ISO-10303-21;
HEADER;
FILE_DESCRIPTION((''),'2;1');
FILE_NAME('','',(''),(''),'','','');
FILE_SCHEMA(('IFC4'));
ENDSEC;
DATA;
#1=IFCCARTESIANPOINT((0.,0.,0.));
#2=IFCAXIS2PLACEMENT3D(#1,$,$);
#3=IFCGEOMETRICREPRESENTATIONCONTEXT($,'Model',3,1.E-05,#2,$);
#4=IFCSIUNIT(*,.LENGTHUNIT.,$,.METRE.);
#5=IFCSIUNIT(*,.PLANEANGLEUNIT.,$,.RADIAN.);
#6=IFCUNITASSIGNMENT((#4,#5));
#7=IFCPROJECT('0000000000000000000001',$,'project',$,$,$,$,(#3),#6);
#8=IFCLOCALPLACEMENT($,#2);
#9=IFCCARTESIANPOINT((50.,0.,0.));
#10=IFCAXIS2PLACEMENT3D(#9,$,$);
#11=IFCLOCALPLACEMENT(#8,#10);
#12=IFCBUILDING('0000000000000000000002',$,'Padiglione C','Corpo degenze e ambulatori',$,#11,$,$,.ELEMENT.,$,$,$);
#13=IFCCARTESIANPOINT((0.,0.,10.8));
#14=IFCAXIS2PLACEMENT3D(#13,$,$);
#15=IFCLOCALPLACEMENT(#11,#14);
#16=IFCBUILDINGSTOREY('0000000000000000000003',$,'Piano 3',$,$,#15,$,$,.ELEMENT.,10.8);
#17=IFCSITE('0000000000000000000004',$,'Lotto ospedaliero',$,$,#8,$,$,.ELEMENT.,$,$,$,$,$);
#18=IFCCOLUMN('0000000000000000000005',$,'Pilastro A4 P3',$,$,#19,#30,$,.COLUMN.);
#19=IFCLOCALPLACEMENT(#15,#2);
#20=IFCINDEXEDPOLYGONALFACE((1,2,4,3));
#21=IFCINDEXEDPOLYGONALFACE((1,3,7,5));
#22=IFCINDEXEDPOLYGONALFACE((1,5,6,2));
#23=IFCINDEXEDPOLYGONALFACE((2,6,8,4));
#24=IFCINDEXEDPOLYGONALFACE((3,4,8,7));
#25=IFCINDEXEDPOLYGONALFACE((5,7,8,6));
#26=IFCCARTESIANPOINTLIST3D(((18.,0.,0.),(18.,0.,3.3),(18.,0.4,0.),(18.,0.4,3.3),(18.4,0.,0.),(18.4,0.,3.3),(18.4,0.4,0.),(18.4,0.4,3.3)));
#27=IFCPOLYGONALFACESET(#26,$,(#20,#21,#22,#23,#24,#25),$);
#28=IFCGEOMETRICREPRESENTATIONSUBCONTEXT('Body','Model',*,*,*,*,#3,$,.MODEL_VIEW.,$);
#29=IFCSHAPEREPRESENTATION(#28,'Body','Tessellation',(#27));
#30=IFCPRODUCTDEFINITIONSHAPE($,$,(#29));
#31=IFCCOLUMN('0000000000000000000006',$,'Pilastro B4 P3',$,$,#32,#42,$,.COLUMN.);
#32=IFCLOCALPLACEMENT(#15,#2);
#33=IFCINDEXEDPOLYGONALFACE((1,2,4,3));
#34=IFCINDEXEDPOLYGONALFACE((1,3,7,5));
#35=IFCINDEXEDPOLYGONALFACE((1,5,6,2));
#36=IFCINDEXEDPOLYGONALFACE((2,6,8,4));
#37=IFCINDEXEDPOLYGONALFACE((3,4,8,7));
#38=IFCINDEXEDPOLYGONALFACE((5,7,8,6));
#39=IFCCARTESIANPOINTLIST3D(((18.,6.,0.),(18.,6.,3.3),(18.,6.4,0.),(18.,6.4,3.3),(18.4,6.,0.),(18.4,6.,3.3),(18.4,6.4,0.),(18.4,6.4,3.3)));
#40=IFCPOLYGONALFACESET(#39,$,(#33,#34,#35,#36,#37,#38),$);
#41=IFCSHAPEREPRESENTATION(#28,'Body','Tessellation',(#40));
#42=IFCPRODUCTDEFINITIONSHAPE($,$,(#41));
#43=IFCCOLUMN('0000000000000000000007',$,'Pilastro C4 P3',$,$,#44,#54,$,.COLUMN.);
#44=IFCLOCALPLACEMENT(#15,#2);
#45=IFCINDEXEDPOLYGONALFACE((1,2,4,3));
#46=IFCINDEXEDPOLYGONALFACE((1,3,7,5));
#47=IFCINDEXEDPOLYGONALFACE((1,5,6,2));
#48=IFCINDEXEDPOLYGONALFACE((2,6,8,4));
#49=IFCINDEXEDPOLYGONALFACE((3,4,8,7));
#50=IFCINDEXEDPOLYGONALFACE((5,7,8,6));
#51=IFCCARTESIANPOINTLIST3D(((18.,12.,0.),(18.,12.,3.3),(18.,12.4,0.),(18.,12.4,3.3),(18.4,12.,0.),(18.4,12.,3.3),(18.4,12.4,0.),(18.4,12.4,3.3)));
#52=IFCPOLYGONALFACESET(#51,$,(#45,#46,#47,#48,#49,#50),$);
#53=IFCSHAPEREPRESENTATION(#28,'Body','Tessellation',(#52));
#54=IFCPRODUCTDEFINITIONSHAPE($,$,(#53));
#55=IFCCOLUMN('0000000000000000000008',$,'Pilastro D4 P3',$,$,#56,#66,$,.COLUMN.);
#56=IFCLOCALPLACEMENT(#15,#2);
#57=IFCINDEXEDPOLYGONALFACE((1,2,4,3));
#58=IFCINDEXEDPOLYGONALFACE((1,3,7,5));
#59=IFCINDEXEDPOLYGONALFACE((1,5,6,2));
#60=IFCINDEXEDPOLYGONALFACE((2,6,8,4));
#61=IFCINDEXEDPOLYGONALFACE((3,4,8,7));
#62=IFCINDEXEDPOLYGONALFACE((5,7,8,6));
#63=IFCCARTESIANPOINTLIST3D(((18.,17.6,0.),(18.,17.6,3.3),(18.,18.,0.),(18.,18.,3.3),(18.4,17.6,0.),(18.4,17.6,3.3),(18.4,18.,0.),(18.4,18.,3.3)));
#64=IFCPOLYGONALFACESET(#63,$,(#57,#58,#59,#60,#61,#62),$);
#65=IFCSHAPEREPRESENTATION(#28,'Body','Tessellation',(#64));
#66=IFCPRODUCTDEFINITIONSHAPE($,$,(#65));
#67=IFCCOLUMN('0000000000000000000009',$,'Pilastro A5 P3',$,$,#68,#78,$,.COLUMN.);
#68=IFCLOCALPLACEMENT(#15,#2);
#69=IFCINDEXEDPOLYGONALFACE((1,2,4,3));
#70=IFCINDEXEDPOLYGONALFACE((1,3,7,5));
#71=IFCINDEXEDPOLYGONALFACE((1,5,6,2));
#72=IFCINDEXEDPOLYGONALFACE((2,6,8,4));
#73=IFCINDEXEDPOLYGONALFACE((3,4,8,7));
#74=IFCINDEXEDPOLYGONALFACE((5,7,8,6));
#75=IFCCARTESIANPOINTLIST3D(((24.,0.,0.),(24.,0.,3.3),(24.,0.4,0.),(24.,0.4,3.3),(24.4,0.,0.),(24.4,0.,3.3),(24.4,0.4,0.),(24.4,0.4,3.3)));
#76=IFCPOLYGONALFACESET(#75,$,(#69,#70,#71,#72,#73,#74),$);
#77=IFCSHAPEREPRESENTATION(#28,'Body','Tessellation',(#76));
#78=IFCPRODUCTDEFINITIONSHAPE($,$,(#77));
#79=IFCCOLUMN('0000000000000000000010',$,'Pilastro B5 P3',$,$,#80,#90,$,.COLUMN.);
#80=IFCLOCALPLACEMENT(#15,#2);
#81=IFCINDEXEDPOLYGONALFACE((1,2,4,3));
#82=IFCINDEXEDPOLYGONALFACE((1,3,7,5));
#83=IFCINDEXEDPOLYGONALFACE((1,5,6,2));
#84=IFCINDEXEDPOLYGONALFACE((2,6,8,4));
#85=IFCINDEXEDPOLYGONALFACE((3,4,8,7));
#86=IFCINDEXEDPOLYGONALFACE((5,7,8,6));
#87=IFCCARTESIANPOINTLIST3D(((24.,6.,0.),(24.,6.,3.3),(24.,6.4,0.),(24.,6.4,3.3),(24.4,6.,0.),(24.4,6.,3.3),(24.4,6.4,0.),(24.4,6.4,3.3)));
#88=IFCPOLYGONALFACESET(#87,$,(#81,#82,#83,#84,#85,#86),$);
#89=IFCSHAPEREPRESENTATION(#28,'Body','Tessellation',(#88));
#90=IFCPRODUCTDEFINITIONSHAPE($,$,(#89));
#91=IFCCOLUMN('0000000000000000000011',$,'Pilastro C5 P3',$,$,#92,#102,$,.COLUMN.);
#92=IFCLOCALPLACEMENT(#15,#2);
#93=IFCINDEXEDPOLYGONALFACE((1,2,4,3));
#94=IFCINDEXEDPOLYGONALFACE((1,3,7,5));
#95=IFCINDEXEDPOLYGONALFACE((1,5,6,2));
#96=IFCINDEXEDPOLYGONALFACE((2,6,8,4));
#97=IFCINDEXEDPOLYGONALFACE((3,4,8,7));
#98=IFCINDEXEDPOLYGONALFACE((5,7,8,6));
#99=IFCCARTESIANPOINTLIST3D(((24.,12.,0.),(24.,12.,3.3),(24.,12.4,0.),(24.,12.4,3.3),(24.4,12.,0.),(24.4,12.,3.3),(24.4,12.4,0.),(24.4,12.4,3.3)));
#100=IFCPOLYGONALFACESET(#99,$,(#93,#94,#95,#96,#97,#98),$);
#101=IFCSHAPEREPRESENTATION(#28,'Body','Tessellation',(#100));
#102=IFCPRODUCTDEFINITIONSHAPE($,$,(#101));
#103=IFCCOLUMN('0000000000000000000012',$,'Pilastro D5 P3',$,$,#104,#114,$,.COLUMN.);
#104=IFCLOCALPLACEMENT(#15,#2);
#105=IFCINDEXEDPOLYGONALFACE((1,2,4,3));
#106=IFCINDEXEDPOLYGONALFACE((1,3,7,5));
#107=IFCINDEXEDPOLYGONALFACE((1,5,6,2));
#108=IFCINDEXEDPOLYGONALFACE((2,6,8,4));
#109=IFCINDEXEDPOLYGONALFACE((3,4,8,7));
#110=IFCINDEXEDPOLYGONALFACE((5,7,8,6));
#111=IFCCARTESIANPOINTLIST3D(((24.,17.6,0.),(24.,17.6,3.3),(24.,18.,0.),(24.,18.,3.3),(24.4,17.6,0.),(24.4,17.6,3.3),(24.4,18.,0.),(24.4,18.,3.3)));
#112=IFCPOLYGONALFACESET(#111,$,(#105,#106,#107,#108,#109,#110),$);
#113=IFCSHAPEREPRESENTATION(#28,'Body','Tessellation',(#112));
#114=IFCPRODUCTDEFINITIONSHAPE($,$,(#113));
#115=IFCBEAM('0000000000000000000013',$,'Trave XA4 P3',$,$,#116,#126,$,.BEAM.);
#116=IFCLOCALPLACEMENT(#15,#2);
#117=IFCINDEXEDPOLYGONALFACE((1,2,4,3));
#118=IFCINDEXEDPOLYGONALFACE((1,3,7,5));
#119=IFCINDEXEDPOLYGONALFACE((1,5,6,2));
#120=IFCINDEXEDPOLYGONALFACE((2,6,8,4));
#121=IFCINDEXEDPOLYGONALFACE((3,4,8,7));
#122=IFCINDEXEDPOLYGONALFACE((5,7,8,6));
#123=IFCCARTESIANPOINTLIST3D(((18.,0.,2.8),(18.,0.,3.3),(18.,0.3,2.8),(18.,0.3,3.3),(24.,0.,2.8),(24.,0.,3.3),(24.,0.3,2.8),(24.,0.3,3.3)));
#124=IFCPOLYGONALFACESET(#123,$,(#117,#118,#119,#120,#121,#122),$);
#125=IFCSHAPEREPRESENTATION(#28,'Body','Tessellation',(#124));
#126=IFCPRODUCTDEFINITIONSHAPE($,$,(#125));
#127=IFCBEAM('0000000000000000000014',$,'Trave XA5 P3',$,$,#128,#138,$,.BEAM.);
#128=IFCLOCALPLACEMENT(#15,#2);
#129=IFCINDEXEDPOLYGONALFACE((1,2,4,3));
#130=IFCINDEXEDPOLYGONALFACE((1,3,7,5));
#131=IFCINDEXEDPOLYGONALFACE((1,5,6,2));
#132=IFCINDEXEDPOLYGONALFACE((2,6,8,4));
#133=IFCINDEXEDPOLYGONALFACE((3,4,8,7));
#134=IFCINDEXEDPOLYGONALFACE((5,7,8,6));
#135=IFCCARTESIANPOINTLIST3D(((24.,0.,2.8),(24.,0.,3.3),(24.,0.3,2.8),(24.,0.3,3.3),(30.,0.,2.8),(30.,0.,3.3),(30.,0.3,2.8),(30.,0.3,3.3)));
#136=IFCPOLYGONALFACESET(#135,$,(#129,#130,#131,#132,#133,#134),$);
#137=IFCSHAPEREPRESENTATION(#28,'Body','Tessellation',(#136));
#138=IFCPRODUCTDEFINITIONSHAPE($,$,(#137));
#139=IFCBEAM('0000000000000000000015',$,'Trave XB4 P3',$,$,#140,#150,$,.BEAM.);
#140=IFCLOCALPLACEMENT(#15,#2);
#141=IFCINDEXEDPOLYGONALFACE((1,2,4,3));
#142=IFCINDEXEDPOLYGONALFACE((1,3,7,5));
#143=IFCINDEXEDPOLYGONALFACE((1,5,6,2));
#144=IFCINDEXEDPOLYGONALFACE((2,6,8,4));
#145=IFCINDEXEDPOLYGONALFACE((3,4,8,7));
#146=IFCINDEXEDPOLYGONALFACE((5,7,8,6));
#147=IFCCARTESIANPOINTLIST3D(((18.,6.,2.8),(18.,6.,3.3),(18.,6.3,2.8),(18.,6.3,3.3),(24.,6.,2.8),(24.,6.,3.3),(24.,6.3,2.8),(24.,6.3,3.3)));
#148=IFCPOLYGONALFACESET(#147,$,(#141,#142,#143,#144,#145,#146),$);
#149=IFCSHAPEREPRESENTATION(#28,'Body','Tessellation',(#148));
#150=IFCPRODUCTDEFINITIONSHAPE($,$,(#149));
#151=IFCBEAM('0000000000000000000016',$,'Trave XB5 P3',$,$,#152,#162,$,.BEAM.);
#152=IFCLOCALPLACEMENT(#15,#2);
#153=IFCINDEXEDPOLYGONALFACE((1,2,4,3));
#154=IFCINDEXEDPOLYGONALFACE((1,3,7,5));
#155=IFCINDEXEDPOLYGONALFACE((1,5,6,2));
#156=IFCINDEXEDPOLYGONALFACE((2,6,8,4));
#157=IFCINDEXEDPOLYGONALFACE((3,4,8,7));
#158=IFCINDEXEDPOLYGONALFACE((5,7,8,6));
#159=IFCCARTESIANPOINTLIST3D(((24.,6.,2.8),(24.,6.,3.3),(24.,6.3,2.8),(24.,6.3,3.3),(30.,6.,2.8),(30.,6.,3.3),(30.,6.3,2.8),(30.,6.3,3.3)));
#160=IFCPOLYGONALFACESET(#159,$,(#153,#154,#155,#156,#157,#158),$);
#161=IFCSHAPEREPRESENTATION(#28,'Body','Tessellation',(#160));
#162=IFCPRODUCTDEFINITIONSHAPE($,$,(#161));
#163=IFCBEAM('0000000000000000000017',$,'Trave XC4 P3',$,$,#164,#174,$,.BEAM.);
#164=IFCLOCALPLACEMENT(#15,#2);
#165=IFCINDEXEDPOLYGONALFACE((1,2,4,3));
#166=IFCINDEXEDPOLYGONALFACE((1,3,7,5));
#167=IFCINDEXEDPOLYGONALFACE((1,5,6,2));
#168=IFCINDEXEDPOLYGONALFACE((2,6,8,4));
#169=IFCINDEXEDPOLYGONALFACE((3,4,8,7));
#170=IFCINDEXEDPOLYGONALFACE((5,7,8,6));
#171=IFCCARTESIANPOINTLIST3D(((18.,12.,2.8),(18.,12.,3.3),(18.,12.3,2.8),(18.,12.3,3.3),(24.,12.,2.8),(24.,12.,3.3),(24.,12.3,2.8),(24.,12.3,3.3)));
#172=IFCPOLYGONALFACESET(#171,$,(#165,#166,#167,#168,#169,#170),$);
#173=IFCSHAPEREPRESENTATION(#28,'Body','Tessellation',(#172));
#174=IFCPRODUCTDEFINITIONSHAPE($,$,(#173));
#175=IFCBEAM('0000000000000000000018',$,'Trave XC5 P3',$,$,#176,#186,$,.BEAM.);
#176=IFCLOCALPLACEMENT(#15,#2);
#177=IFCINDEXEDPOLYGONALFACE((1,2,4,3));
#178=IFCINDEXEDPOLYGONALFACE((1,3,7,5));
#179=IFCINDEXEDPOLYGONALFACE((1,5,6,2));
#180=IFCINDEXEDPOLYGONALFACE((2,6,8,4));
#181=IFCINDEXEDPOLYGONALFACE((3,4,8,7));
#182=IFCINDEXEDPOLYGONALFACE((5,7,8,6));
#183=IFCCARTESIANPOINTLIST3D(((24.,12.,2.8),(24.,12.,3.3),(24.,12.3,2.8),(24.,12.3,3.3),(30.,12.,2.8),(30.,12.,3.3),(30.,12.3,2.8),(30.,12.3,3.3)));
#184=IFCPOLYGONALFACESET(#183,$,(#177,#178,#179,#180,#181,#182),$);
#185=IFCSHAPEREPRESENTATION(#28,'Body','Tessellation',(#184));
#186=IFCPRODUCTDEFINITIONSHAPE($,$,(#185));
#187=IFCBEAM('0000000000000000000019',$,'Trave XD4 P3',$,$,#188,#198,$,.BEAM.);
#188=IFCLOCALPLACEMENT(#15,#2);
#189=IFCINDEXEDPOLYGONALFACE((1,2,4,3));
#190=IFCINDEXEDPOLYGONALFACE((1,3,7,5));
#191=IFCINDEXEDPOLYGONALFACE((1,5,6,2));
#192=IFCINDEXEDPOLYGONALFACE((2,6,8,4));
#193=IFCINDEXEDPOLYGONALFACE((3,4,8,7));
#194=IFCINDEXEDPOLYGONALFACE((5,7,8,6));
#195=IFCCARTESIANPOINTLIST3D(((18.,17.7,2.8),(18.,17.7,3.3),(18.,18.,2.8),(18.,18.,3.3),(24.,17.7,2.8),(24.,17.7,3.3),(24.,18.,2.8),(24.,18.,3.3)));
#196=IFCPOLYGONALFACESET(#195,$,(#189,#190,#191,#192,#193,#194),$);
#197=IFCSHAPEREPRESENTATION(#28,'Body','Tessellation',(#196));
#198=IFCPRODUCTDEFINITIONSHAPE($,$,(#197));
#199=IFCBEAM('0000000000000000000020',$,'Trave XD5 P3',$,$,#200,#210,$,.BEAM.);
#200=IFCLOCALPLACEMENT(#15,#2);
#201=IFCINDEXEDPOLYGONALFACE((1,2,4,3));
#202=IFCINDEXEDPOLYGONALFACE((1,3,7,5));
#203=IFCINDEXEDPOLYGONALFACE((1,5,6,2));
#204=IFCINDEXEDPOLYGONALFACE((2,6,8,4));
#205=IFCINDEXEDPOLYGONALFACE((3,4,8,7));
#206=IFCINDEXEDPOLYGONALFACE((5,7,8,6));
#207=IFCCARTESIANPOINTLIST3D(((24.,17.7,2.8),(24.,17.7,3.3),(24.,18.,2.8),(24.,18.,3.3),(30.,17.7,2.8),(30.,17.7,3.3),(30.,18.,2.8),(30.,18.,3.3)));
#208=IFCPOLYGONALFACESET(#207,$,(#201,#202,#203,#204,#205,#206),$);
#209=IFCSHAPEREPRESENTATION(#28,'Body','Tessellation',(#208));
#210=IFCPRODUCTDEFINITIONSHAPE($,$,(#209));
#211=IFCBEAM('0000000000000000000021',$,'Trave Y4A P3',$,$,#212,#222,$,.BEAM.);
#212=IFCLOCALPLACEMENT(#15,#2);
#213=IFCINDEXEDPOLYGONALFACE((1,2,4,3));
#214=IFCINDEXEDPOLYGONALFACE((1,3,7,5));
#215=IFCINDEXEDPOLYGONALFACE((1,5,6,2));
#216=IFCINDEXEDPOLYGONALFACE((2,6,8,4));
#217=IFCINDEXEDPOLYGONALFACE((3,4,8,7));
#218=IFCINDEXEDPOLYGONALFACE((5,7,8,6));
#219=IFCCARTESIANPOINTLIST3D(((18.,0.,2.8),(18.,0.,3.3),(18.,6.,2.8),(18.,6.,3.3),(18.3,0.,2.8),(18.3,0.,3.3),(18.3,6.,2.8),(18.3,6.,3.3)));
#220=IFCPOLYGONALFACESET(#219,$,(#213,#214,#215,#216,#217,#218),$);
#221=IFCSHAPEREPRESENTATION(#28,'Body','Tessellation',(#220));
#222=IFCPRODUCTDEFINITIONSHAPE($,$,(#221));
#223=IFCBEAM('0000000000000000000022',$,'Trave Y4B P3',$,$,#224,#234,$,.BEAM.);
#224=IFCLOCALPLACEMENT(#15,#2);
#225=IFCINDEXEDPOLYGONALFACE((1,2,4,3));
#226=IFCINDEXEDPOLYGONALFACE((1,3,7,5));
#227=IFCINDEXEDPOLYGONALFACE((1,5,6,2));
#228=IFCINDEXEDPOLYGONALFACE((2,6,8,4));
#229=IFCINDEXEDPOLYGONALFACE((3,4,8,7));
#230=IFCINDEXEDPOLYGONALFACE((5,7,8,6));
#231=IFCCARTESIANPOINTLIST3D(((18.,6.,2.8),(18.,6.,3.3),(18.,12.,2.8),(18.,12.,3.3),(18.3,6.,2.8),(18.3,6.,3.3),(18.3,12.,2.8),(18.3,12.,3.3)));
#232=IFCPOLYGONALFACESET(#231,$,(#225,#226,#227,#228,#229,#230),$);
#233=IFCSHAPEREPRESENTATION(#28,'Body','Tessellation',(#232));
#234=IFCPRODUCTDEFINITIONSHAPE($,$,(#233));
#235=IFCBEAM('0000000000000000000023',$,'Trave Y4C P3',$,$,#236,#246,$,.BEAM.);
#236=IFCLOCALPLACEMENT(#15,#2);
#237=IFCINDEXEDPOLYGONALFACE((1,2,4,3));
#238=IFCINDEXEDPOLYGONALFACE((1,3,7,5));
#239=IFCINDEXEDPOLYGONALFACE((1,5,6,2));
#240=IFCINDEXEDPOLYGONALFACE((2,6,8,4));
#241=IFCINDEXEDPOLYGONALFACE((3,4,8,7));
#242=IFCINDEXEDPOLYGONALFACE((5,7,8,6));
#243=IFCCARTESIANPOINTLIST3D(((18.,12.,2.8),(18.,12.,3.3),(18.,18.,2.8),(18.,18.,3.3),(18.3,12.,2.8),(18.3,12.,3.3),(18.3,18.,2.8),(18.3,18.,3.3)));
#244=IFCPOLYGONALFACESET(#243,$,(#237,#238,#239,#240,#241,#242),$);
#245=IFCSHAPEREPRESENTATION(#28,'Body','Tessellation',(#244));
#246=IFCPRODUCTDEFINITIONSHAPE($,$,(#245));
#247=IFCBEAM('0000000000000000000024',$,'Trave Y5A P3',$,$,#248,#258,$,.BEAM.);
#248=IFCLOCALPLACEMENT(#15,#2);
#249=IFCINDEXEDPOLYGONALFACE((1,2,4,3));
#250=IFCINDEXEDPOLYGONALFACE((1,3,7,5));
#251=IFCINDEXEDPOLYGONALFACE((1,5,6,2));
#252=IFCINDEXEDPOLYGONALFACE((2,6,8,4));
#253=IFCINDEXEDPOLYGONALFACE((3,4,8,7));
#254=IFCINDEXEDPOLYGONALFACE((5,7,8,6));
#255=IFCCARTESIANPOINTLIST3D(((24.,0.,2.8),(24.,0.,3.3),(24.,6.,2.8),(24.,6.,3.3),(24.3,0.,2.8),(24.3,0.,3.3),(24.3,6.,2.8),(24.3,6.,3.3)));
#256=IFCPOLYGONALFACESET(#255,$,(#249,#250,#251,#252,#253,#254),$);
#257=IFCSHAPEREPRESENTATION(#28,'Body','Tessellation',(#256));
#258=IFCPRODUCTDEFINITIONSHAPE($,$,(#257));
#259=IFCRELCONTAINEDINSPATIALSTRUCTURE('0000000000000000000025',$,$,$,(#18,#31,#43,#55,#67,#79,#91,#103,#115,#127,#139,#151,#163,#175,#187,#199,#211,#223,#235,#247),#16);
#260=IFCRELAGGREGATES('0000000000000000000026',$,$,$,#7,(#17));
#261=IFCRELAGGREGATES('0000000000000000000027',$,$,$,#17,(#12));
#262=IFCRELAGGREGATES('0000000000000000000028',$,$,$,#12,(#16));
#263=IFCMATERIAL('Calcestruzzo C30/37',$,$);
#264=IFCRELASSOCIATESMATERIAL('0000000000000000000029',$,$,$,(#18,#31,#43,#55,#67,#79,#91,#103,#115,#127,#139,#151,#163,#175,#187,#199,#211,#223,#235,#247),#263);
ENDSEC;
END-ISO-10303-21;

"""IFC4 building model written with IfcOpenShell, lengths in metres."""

from ifc_helpers import new_model, si_unit, frame, frame_2d, origin, place, context, subcontext, project, spatial, rectangle, extrude, material, element, save


model = new_model("IFC4")

# Units and contexts
model_context = context("Model", 3, precision=1e-05, world=origin())
body_context = subcontext(model_context, "Body", "Model", "MODEL_VIEW")
ifc_project = project(units=[si_unit("LENGTHUNIT", "METRE"), si_unit("PLANEANGLEUNIT", "RADIAN")], contexts=[model_context])

# Site, building, storey
site_placement = place(None, origin())
site = spatial("IfcSite", under=ifc_project, at=site_placement, Name="Lotto ospedaliero", CompositionType="ELEMENT")
building_placement = place(site_placement, frame((50.0, 0.0, 0.0)))
building = spatial("IfcBuilding", under=site, at=building_placement, Name="Padiglione C", Description="Corpo degenze e ambulatori", CompositionType="ELEMENT")
storey_placement = place(building_placement, frame((0.0, 0.0, 10.8)))
storey = spatial("IfcBuildingStorey", under=building, at=storey_placement, Name="Piano 3", CompositionType="ELEMENT", Elevation=10.8)

# Columns
ifc_material_1 = material(Name="Calcestruzzo C30/37")
for number, where, name in (
    (1, (18.0, 0.0, 0.0), "Pilastro A4 P3"),
    (2, (18.0, 6.0, 0.0), "Pilastro B4 P3"),
    (3, (18.0, 12.0, 0.0), "Pilastro C4 P3"),
    (4, (18.0, 17.6, 0.0), "Pilastro D4 P3"),
    (5, (24.0, 0.0, 0.0), "Pilastro A5 P3"),
    (6, (24.0, 6.0, 0.0), "Pilastro B5 P3"),
    (7, (24.0, 12.0, 0.0), "Pilastro C5 P3"),
    (8, (24.0, 17.6, 0.0), "Pilastro D5 P3"),
):
    element("IfcColumn", number, at=place(storey_placement, frame(where)), inside=storey, material=ifc_material_1, Name=name, PredefinedType="COLUMN", context=body_context, shape_type="SweptSolid", body=[
        extrude(rectangle(XDim=0.4, YDim=0.4, at=frame_2d((0.2, 0.2))), origin(), (0.0, 0.0, 1.0), 3.3),
    ])

# Beams
for number, where, name in (
    (9, (18.0, 0.0, 2.8), "Trave XA4 P3"),
    (10, (24.0, 0.0, 2.8), "Trave XA5 P3"),
    (11, (18.0, 6.0, 2.8), "Trave XB4 P3"),
    (12, (24.0, 6.0, 2.8), "Trave XB5 P3"),
    (13, (18.0, 12.0, 2.8), "Trave XC4 P3"),
    (14, (24.0, 12.0, 2.8), "Trave XC5 P3"),
    (15, (18.0, 17.7, 2.8), "Trave XD4 P3"),
    (16, (24.0, 17.7, 2.8), "Trave XD5 P3"),
):
    element("IfcBeam", number, at=place(storey_placement, frame(where)), inside=storey, material=ifc_material_1, Name=name, PredefinedType="BEAM", context=body_context, shape_type="SweptSolid", body=[
        extrude(rectangle(XDim=6.0, YDim=0.3, at=frame_2d((3.0, 0.15))), origin(), (0.0, 0.0, 1.0), 0.5),
    ])
for number, where, name in (
    (17, (18.0, 0.0, 2.8), "Trave Y4A P3"),
    (18, (18.0, 6.0, 2.8), "Trave Y4B P3"),
    (19, (18.0, 12.0, 2.8), "Trave Y4C P3"),
    (20, (24.0, 0.0, 2.8), "Trave Y5A P3"),
):
    element("IfcBeam", number, at=place(storey_placement, frame(where)), inside=storey, material=ifc_material_1, Name=name, PredefinedType="BEAM", context=body_context, shape_type="SweptSolid", body=[
        extrude(rectangle(XDim=0.3, YDim=6.0, at=frame_2d((0.15, 3.0))), origin(), (0.0, 0.0, 1.0), 0.5),
    ])

save(model, "model.ifc")
